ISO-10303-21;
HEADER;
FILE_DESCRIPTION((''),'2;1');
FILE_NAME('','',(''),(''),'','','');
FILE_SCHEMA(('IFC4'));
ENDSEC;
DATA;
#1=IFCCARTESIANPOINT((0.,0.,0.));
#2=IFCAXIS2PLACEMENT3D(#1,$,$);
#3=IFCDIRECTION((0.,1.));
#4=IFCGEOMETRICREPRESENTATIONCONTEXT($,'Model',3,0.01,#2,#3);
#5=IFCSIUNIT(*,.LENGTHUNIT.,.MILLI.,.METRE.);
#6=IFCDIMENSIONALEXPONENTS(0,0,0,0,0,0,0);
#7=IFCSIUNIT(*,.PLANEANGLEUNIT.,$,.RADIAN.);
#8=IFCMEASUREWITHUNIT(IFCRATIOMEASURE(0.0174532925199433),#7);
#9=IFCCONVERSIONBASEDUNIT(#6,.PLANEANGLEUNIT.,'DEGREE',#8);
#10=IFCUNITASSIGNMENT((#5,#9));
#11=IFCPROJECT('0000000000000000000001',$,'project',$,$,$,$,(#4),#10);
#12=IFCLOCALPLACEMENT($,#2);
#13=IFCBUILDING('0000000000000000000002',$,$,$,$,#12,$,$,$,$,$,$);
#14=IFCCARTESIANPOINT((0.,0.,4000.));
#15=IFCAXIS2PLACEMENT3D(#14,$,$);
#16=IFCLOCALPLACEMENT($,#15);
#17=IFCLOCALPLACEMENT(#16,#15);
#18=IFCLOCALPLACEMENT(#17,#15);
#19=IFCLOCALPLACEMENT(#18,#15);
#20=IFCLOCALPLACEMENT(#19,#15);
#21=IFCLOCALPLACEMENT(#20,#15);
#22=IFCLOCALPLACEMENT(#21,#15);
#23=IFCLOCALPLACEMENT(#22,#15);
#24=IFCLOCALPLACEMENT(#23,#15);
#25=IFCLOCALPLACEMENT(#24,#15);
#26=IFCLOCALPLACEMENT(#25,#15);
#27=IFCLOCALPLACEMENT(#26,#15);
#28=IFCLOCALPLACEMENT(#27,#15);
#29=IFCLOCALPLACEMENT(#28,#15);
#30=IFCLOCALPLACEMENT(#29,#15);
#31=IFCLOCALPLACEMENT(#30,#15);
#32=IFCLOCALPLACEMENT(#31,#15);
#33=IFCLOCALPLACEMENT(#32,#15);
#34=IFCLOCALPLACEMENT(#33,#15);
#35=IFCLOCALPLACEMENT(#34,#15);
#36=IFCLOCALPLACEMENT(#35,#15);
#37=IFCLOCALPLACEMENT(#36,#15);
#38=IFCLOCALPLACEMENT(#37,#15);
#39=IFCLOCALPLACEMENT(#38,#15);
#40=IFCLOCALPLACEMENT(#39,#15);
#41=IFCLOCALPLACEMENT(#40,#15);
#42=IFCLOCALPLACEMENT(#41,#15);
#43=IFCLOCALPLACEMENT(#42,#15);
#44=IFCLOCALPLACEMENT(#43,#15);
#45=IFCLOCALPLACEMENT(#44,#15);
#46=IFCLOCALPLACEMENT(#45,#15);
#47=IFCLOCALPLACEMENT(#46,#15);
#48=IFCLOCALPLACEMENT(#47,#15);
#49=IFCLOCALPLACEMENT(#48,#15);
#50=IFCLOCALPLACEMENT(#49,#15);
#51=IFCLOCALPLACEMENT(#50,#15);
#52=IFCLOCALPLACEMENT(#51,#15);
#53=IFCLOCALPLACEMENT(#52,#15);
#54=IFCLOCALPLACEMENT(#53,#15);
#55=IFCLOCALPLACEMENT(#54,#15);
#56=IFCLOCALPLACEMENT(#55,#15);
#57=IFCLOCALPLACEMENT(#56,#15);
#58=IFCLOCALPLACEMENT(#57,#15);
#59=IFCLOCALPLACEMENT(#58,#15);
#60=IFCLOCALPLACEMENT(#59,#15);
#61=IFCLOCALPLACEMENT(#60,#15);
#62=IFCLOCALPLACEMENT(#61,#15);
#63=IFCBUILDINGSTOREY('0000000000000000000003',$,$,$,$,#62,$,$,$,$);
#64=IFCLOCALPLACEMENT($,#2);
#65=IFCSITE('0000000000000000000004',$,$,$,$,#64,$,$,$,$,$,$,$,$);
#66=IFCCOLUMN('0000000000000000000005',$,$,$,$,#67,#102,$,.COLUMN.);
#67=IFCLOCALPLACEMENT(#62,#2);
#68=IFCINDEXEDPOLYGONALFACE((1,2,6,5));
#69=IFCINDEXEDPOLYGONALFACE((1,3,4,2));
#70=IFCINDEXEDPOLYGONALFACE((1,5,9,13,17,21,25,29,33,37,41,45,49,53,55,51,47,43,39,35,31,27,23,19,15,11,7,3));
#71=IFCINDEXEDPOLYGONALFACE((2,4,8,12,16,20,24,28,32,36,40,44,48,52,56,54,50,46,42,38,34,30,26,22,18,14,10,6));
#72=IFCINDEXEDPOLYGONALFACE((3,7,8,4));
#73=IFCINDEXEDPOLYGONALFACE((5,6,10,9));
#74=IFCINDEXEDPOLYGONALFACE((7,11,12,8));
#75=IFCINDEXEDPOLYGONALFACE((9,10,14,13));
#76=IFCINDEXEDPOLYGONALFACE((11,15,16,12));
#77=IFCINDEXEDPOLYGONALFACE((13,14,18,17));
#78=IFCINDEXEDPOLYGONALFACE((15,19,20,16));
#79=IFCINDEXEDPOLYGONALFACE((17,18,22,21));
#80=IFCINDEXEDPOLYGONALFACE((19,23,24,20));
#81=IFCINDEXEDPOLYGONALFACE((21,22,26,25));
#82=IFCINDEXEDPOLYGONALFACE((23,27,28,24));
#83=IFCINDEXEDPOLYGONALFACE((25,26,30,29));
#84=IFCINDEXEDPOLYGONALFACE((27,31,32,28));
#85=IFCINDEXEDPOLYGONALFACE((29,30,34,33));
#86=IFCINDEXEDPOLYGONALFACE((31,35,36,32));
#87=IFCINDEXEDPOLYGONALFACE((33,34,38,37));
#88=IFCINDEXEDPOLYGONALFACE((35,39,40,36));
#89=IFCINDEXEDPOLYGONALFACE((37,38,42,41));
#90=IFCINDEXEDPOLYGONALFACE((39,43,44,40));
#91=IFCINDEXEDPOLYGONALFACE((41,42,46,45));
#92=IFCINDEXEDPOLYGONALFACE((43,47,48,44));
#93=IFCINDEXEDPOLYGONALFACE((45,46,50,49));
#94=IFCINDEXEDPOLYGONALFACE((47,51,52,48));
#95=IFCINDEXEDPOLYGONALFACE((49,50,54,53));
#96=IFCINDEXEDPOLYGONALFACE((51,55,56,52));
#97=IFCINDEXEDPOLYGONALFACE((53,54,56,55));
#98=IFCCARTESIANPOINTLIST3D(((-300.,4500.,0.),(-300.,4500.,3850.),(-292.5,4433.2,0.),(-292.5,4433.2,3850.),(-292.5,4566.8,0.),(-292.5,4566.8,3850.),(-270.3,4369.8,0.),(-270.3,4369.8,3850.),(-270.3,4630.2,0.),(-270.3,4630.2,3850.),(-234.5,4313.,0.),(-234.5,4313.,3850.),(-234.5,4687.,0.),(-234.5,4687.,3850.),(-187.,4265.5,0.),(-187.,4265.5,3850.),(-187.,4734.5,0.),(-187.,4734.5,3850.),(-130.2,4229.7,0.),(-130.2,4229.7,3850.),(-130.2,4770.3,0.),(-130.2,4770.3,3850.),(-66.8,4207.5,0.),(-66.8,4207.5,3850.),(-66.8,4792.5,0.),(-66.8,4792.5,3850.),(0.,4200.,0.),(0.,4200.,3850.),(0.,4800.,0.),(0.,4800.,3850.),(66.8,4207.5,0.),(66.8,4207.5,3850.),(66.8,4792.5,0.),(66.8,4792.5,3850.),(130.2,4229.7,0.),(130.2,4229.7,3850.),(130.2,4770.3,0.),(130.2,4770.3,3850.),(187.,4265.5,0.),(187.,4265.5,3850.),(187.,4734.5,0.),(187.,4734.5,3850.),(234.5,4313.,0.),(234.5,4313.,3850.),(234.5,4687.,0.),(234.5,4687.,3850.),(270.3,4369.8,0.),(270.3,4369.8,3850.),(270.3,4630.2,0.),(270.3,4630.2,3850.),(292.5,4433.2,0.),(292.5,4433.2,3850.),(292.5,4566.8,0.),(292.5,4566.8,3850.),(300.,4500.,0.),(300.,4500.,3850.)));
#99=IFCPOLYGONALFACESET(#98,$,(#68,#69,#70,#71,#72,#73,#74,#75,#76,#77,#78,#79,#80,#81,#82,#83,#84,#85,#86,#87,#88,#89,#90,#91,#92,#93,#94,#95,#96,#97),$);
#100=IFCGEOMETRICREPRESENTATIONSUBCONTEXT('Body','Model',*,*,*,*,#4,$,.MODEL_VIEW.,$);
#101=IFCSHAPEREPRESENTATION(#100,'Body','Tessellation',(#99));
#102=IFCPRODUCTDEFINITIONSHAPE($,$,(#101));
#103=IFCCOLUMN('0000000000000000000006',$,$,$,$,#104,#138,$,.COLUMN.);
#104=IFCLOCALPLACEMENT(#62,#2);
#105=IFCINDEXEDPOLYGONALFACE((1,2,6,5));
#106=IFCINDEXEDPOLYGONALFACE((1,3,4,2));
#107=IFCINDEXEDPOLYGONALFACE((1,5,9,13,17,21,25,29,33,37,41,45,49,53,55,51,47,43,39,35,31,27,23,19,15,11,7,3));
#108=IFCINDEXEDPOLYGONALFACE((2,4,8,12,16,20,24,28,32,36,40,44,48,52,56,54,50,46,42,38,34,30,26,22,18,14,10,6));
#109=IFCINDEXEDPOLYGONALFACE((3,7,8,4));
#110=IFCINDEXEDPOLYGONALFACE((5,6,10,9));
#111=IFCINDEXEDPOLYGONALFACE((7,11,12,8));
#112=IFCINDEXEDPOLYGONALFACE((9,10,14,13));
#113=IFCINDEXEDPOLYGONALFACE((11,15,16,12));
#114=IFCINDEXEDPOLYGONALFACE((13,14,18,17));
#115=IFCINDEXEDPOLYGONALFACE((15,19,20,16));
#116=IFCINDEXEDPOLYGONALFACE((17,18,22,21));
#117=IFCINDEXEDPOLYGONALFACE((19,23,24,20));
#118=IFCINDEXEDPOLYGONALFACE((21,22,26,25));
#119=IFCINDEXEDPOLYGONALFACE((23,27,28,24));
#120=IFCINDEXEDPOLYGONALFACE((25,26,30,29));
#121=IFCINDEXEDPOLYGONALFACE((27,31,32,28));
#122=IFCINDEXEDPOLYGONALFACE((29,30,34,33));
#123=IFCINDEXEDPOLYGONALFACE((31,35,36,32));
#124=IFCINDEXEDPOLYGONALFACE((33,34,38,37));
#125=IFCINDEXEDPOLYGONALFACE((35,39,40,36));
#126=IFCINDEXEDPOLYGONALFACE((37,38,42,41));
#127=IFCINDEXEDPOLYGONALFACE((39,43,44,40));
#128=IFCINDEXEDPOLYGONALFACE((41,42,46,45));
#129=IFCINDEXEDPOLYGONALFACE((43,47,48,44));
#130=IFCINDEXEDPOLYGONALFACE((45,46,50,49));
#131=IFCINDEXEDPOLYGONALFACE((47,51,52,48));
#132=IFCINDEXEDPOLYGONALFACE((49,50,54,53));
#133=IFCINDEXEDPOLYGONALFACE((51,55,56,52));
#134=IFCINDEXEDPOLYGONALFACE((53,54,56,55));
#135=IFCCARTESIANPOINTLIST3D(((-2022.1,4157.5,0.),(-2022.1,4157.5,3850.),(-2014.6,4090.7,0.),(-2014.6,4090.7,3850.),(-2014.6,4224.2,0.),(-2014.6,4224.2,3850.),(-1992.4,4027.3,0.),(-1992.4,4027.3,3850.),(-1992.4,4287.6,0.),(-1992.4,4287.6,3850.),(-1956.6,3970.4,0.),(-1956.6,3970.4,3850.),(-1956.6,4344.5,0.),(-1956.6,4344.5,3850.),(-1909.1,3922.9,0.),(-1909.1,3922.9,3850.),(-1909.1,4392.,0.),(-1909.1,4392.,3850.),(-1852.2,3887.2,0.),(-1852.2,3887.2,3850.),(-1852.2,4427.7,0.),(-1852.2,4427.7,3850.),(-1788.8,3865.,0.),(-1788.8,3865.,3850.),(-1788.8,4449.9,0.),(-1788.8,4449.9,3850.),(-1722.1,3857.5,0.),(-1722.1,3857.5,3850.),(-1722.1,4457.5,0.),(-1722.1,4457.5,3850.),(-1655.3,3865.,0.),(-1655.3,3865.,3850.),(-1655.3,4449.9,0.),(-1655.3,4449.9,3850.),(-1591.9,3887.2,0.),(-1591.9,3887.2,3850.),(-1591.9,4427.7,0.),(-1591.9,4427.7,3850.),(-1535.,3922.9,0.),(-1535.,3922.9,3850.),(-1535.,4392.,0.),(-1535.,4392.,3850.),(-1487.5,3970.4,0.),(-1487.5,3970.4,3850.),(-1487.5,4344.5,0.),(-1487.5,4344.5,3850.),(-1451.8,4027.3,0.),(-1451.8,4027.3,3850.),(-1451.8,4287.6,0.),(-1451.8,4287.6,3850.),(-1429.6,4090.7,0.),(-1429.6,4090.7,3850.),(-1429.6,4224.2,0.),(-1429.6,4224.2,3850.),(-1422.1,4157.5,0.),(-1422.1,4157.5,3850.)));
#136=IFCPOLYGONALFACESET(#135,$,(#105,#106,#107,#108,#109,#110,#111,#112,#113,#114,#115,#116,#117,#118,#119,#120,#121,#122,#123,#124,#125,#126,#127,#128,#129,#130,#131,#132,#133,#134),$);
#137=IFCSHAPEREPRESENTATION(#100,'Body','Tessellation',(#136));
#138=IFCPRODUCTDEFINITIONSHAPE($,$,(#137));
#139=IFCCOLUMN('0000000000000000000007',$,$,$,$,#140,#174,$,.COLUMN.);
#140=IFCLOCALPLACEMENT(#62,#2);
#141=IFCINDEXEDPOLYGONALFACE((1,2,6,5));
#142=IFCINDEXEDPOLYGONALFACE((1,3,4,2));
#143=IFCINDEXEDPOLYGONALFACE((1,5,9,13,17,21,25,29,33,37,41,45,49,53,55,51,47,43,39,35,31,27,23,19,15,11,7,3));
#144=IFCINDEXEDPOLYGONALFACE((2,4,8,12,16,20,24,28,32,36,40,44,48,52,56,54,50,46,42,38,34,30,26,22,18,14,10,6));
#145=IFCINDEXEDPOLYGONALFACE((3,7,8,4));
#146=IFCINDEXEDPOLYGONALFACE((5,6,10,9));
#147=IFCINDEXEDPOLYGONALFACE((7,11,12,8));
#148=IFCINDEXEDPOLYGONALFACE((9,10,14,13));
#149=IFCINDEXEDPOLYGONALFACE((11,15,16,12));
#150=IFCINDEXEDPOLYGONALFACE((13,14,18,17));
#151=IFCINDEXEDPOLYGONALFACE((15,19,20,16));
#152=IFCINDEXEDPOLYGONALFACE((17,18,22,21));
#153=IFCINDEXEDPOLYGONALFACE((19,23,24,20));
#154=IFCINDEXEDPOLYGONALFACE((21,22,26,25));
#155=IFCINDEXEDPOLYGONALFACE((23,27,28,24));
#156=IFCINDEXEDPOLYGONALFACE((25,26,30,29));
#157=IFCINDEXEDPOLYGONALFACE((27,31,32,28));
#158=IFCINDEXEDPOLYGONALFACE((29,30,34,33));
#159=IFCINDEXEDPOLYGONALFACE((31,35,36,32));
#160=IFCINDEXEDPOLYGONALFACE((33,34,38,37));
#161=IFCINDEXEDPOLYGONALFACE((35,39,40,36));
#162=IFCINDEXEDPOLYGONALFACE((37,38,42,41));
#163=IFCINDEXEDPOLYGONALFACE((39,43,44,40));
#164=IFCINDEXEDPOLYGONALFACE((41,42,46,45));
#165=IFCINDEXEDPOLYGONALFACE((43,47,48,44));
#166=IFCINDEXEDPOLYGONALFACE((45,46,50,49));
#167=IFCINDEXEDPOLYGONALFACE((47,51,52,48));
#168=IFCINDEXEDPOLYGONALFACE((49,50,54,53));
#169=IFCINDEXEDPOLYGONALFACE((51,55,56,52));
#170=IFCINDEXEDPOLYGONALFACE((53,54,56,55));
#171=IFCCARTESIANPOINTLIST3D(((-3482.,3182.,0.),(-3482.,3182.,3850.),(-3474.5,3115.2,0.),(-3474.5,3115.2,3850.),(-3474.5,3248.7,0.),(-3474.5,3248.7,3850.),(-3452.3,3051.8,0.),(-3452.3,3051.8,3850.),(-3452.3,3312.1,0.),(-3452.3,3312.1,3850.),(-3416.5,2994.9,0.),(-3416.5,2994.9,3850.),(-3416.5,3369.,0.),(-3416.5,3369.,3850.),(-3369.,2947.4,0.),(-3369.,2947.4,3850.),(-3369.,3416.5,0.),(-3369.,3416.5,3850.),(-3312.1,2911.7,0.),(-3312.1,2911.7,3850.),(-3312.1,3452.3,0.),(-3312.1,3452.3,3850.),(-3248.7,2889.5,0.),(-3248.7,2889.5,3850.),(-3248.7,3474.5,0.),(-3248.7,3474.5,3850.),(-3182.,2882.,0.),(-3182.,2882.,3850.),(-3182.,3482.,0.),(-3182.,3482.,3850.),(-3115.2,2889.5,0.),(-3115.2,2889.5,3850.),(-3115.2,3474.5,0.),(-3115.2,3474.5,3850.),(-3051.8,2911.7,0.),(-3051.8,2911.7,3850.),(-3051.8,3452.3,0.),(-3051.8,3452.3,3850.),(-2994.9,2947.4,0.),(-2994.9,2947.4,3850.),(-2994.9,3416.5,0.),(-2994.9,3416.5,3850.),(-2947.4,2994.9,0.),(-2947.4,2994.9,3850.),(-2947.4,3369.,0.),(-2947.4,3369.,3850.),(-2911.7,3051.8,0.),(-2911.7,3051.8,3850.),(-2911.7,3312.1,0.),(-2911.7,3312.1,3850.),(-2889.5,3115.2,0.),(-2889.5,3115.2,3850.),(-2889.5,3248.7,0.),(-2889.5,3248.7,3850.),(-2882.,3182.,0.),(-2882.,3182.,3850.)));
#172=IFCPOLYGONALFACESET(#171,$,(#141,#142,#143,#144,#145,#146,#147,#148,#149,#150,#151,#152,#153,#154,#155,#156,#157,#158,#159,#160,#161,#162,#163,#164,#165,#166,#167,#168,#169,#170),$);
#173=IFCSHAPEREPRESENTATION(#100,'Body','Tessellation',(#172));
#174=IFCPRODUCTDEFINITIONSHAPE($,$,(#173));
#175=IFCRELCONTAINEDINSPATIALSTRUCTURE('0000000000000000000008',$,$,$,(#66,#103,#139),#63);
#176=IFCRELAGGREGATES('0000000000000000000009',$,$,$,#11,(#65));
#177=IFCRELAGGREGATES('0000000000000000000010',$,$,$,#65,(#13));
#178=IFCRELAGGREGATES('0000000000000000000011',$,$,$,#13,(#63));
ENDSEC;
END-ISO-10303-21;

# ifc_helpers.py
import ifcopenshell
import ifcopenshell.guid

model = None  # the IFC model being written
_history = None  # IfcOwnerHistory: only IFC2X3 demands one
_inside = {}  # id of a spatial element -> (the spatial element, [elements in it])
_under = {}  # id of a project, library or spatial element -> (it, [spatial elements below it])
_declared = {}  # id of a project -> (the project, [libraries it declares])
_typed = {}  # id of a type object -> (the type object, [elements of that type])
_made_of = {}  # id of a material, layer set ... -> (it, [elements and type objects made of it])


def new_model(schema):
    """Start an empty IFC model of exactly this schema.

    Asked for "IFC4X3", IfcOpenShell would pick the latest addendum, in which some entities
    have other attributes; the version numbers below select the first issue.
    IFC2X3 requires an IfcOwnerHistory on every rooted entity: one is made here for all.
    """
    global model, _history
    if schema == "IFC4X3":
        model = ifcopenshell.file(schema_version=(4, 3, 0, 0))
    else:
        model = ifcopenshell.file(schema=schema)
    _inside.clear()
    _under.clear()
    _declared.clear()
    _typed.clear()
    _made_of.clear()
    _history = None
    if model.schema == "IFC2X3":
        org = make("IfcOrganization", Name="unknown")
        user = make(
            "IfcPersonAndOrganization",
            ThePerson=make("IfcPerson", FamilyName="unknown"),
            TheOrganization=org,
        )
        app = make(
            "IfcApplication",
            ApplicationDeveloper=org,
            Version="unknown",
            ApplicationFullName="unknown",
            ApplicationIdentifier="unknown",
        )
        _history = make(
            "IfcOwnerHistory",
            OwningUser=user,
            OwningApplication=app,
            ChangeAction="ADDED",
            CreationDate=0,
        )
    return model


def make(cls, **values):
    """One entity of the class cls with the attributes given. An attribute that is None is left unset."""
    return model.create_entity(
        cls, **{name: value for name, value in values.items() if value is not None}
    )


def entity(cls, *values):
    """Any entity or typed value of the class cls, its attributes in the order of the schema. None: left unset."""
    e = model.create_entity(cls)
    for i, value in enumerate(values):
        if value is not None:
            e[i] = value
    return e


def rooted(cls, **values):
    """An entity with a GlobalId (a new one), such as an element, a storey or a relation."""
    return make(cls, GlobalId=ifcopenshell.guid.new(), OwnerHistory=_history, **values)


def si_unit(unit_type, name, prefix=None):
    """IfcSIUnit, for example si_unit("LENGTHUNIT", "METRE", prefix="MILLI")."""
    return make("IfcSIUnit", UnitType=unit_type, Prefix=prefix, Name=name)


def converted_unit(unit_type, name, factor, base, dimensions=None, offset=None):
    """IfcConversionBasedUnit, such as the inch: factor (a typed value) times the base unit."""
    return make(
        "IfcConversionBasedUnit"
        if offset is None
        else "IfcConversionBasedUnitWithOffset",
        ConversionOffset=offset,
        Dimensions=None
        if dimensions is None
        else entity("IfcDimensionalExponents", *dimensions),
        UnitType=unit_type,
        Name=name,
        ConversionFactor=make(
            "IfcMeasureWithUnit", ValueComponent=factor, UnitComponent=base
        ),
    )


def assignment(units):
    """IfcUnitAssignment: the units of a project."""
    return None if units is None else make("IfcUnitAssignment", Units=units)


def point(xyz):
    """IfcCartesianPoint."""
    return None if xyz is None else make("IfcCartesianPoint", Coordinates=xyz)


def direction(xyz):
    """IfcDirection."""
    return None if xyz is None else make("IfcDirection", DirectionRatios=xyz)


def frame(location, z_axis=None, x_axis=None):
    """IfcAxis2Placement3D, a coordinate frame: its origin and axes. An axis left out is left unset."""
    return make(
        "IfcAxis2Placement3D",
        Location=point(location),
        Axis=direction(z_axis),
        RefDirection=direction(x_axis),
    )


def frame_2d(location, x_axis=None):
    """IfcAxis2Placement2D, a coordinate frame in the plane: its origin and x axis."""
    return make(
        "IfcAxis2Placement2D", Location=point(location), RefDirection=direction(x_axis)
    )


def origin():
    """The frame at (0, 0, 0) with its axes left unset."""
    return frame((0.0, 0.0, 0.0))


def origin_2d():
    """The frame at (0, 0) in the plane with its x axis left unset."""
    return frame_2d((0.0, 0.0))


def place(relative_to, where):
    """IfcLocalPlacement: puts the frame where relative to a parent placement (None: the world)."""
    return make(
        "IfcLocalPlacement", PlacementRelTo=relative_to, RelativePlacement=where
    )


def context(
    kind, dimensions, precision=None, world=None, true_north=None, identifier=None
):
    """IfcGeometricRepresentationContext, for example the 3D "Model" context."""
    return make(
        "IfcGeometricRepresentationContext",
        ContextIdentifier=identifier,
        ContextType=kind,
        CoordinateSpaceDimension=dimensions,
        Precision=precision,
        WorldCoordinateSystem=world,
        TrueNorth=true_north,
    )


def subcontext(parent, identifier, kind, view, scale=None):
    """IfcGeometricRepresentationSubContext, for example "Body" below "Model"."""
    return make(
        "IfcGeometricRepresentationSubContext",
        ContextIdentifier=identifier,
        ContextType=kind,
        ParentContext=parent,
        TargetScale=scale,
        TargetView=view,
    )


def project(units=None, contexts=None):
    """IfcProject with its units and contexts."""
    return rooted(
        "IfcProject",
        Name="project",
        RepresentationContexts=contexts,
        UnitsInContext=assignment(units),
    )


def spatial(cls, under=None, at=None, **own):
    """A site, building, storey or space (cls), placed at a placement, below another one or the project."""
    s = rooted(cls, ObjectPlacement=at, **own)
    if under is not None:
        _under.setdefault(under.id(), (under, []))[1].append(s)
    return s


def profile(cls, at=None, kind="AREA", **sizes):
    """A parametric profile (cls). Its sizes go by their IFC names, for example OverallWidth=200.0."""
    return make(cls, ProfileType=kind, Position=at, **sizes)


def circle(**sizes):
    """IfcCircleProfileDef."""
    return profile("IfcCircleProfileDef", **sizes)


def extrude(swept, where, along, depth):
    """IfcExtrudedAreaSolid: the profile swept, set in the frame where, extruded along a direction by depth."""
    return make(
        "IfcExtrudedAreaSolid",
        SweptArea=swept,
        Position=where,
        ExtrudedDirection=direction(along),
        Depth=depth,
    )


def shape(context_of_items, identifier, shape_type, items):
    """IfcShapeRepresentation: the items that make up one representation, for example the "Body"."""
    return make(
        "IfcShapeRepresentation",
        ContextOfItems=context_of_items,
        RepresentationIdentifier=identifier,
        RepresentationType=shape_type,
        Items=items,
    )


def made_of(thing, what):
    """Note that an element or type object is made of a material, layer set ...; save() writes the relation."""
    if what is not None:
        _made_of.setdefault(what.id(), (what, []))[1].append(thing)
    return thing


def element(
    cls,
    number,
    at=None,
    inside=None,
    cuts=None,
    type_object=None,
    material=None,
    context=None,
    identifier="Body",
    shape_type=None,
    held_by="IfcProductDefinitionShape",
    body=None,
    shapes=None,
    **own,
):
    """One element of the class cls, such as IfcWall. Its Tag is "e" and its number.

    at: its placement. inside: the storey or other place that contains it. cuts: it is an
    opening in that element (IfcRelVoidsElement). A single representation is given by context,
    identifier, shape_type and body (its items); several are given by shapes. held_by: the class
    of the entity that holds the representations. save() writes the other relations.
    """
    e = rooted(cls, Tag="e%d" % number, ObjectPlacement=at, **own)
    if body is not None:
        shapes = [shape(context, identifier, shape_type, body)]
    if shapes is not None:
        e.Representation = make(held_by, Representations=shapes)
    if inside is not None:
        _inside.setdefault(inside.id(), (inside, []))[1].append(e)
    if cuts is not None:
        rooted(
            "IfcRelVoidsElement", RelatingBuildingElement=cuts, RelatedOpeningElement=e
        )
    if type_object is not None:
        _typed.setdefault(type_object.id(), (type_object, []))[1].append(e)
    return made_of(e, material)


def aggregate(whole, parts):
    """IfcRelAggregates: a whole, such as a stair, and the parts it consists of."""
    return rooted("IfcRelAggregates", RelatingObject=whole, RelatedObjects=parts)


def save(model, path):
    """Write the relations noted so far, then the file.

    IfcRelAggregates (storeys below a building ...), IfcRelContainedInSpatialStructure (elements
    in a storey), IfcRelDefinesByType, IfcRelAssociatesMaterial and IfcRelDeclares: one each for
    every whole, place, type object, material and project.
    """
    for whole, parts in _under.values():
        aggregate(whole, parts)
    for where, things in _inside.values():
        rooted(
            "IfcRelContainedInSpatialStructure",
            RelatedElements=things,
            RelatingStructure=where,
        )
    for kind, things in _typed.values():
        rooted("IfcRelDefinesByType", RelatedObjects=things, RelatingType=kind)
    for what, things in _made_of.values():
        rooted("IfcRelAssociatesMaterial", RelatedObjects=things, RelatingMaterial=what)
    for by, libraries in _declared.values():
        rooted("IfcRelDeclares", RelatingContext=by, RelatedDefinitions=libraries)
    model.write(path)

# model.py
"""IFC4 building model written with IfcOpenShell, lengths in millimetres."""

from ifc_helpers import new_model, entity, si_unit, converted_unit, direction, frame, origin, origin_2d, place, context, subcontext, project, spatial, circle, extrude, element, save


model = new_model("IFC4")

# Units and contexts
model_context = context("Model", 3, precision=0.01, world=origin(), true_north=direction((0.0, 1.0)))
body_context = subcontext(model_context, "Body", "Model", "MODEL_VIEW")
ifc_project = project(units=[si_unit("LENGTHUNIT", "METRE", prefix="MILLI"), converted_unit("PLANEANGLEUNIT", "DEGREE", entity("IfcRatioMeasure", 0.0174532925199433), si_unit("PLANEANGLEUNIT", "RADIAN"), dimensions=[0, 0, 0, 0, 0, 0, 0])], contexts=[model_context])

# Site, building, storey
site_placement = place(None, origin())
site = spatial("IfcSite", under=ifc_project, at=site_placement)
building_placement = place(None, origin())
building = spatial("IfcBuilding", under=site, at=building_placement)
placement_1 = place(None, frame((0.0, 0.0, 4000.0)))
placement_2 = place(placement_1, frame((0.0, 0.0, 4000.0)))
placement_3 = place(placement_2, frame((0.0, 0.0, 4000.0)))
placement_4 = place(placement_3, frame((0.0, 0.0, 4000.0)))
placement_5 = place(placement_4, frame((0.0, 0.0, 4000.0)))
placement_6 = place(placement_5, frame((0.0, 0.0, 4000.0)))
placement_7 = place(placement_6, frame((0.0, 0.0, 4000.0)))
placement_8 = place(placement_7, frame((0.0, 0.0, 4000.0)))
placement_9 = place(placement_8, frame((0.0, 0.0, 4000.0)))
placement_10 = place(placement_9, frame((0.0, 0.0, 4000.0)))
placement_11 = place(placement_10, frame((0.0, 0.0, 4000.0)))
placement_12 = place(placement_11, frame((0.0, 0.0, 4000.0)))
placement_13 = place(placement_12, frame((0.0, 0.0, 4000.0)))
placement_14 = place(placement_13, frame((0.0, 0.0, 4000.0)))
placement_15 = place(placement_14, frame((0.0, 0.0, 4000.0)))
placement_16 = place(placement_15, frame((0.0, 0.0, 4000.0)))
placement_17 = place(placement_16, frame((0.0, 0.0, 4000.0)))
placement_18 = place(placement_17, frame((0.0, 0.0, 4000.0)))
placement_19 = place(placement_18, frame((0.0, 0.0, 4000.0)))
placement_20 = place(placement_19, frame((0.0, 0.0, 4000.0)))
placement_21 = place(placement_20, frame((0.0, 0.0, 4000.0)))
placement_22 = place(placement_21, frame((0.0, 0.0, 4000.0)))
placement_23 = place(placement_22, frame((0.0, 0.0, 4000.0)))
placement_24 = place(placement_23, frame((0.0, 0.0, 4000.0)))
placement_25 = place(placement_24, frame((0.0, 0.0, 4000.0)))
placement_26 = place(placement_25, frame((0.0, 0.0, 4000.0)))
placement_27 = place(placement_26, frame((0.0, 0.0, 4000.0)))
placement_28 = place(placement_27, frame((0.0, 0.0, 4000.0)))
placement_29 = place(placement_28, frame((0.0, 0.0, 4000.0)))
placement_30 = place(placement_29, frame((0.0, 0.0, 4000.0)))
placement_31 = place(placement_30, frame((0.0, 0.0, 4000.0)))
placement_32 = place(placement_31, frame((0.0, 0.0, 4000.0)))
placement_33 = place(placement_32, frame((0.0, 0.0, 4000.0)))
placement_34 = place(placement_33, frame((0.0, 0.0, 4000.0)))
placement_35 = place(placement_34, frame((0.0, 0.0, 4000.0)))
placement_36 = place(placement_35, frame((0.0, 0.0, 4000.0)))
placement_37 = place(placement_36, frame((0.0, 0.0, 4000.0)))
placement_38 = place(placement_37, frame((0.0, 0.0, 4000.0)))
placement_39 = place(placement_38, frame((0.0, 0.0, 4000.0)))
placement_40 = place(placement_39, frame((0.0, 0.0, 4000.0)))
placement_41 = place(placement_40, frame((0.0, 0.0, 4000.0)))
placement_42 = place(placement_41, frame((0.0, 0.0, 4000.0)))
placement_43 = place(placement_42, frame((0.0, 0.0, 4000.0)))
placement_44 = place(placement_43, frame((0.0, 0.0, 4000.0)))
placement_45 = place(placement_44, frame((0.0, 0.0, 4000.0)))
placement_46 = place(placement_45, frame((0.0, 0.0, 4000.0)))
storey_placement = place(placement_46, frame((0.0, 0.0, 4000.0)))
storey = spatial("IfcBuildingStorey", under=building, at=storey_placement)

# Columns
for number, where in (
    (1, (0.0, 4500.0, 0.0)),
    (2, (-1722.1, 4157.5, 0.0)),
    (3, (-3182.0, 3182.0, 0.0)),
):
    element("IfcColumn", number, at=place(storey_placement, frame(where)), inside=storey, PredefinedType="COLUMN", context=body_context, shape_type="SweptSolid", body=[
        extrude(circle(Radius=300.0, at=origin_2d()), origin(), (0.0, 0.0, 1.0), 3850.0),
    ])

save(model, "model.ifc")
